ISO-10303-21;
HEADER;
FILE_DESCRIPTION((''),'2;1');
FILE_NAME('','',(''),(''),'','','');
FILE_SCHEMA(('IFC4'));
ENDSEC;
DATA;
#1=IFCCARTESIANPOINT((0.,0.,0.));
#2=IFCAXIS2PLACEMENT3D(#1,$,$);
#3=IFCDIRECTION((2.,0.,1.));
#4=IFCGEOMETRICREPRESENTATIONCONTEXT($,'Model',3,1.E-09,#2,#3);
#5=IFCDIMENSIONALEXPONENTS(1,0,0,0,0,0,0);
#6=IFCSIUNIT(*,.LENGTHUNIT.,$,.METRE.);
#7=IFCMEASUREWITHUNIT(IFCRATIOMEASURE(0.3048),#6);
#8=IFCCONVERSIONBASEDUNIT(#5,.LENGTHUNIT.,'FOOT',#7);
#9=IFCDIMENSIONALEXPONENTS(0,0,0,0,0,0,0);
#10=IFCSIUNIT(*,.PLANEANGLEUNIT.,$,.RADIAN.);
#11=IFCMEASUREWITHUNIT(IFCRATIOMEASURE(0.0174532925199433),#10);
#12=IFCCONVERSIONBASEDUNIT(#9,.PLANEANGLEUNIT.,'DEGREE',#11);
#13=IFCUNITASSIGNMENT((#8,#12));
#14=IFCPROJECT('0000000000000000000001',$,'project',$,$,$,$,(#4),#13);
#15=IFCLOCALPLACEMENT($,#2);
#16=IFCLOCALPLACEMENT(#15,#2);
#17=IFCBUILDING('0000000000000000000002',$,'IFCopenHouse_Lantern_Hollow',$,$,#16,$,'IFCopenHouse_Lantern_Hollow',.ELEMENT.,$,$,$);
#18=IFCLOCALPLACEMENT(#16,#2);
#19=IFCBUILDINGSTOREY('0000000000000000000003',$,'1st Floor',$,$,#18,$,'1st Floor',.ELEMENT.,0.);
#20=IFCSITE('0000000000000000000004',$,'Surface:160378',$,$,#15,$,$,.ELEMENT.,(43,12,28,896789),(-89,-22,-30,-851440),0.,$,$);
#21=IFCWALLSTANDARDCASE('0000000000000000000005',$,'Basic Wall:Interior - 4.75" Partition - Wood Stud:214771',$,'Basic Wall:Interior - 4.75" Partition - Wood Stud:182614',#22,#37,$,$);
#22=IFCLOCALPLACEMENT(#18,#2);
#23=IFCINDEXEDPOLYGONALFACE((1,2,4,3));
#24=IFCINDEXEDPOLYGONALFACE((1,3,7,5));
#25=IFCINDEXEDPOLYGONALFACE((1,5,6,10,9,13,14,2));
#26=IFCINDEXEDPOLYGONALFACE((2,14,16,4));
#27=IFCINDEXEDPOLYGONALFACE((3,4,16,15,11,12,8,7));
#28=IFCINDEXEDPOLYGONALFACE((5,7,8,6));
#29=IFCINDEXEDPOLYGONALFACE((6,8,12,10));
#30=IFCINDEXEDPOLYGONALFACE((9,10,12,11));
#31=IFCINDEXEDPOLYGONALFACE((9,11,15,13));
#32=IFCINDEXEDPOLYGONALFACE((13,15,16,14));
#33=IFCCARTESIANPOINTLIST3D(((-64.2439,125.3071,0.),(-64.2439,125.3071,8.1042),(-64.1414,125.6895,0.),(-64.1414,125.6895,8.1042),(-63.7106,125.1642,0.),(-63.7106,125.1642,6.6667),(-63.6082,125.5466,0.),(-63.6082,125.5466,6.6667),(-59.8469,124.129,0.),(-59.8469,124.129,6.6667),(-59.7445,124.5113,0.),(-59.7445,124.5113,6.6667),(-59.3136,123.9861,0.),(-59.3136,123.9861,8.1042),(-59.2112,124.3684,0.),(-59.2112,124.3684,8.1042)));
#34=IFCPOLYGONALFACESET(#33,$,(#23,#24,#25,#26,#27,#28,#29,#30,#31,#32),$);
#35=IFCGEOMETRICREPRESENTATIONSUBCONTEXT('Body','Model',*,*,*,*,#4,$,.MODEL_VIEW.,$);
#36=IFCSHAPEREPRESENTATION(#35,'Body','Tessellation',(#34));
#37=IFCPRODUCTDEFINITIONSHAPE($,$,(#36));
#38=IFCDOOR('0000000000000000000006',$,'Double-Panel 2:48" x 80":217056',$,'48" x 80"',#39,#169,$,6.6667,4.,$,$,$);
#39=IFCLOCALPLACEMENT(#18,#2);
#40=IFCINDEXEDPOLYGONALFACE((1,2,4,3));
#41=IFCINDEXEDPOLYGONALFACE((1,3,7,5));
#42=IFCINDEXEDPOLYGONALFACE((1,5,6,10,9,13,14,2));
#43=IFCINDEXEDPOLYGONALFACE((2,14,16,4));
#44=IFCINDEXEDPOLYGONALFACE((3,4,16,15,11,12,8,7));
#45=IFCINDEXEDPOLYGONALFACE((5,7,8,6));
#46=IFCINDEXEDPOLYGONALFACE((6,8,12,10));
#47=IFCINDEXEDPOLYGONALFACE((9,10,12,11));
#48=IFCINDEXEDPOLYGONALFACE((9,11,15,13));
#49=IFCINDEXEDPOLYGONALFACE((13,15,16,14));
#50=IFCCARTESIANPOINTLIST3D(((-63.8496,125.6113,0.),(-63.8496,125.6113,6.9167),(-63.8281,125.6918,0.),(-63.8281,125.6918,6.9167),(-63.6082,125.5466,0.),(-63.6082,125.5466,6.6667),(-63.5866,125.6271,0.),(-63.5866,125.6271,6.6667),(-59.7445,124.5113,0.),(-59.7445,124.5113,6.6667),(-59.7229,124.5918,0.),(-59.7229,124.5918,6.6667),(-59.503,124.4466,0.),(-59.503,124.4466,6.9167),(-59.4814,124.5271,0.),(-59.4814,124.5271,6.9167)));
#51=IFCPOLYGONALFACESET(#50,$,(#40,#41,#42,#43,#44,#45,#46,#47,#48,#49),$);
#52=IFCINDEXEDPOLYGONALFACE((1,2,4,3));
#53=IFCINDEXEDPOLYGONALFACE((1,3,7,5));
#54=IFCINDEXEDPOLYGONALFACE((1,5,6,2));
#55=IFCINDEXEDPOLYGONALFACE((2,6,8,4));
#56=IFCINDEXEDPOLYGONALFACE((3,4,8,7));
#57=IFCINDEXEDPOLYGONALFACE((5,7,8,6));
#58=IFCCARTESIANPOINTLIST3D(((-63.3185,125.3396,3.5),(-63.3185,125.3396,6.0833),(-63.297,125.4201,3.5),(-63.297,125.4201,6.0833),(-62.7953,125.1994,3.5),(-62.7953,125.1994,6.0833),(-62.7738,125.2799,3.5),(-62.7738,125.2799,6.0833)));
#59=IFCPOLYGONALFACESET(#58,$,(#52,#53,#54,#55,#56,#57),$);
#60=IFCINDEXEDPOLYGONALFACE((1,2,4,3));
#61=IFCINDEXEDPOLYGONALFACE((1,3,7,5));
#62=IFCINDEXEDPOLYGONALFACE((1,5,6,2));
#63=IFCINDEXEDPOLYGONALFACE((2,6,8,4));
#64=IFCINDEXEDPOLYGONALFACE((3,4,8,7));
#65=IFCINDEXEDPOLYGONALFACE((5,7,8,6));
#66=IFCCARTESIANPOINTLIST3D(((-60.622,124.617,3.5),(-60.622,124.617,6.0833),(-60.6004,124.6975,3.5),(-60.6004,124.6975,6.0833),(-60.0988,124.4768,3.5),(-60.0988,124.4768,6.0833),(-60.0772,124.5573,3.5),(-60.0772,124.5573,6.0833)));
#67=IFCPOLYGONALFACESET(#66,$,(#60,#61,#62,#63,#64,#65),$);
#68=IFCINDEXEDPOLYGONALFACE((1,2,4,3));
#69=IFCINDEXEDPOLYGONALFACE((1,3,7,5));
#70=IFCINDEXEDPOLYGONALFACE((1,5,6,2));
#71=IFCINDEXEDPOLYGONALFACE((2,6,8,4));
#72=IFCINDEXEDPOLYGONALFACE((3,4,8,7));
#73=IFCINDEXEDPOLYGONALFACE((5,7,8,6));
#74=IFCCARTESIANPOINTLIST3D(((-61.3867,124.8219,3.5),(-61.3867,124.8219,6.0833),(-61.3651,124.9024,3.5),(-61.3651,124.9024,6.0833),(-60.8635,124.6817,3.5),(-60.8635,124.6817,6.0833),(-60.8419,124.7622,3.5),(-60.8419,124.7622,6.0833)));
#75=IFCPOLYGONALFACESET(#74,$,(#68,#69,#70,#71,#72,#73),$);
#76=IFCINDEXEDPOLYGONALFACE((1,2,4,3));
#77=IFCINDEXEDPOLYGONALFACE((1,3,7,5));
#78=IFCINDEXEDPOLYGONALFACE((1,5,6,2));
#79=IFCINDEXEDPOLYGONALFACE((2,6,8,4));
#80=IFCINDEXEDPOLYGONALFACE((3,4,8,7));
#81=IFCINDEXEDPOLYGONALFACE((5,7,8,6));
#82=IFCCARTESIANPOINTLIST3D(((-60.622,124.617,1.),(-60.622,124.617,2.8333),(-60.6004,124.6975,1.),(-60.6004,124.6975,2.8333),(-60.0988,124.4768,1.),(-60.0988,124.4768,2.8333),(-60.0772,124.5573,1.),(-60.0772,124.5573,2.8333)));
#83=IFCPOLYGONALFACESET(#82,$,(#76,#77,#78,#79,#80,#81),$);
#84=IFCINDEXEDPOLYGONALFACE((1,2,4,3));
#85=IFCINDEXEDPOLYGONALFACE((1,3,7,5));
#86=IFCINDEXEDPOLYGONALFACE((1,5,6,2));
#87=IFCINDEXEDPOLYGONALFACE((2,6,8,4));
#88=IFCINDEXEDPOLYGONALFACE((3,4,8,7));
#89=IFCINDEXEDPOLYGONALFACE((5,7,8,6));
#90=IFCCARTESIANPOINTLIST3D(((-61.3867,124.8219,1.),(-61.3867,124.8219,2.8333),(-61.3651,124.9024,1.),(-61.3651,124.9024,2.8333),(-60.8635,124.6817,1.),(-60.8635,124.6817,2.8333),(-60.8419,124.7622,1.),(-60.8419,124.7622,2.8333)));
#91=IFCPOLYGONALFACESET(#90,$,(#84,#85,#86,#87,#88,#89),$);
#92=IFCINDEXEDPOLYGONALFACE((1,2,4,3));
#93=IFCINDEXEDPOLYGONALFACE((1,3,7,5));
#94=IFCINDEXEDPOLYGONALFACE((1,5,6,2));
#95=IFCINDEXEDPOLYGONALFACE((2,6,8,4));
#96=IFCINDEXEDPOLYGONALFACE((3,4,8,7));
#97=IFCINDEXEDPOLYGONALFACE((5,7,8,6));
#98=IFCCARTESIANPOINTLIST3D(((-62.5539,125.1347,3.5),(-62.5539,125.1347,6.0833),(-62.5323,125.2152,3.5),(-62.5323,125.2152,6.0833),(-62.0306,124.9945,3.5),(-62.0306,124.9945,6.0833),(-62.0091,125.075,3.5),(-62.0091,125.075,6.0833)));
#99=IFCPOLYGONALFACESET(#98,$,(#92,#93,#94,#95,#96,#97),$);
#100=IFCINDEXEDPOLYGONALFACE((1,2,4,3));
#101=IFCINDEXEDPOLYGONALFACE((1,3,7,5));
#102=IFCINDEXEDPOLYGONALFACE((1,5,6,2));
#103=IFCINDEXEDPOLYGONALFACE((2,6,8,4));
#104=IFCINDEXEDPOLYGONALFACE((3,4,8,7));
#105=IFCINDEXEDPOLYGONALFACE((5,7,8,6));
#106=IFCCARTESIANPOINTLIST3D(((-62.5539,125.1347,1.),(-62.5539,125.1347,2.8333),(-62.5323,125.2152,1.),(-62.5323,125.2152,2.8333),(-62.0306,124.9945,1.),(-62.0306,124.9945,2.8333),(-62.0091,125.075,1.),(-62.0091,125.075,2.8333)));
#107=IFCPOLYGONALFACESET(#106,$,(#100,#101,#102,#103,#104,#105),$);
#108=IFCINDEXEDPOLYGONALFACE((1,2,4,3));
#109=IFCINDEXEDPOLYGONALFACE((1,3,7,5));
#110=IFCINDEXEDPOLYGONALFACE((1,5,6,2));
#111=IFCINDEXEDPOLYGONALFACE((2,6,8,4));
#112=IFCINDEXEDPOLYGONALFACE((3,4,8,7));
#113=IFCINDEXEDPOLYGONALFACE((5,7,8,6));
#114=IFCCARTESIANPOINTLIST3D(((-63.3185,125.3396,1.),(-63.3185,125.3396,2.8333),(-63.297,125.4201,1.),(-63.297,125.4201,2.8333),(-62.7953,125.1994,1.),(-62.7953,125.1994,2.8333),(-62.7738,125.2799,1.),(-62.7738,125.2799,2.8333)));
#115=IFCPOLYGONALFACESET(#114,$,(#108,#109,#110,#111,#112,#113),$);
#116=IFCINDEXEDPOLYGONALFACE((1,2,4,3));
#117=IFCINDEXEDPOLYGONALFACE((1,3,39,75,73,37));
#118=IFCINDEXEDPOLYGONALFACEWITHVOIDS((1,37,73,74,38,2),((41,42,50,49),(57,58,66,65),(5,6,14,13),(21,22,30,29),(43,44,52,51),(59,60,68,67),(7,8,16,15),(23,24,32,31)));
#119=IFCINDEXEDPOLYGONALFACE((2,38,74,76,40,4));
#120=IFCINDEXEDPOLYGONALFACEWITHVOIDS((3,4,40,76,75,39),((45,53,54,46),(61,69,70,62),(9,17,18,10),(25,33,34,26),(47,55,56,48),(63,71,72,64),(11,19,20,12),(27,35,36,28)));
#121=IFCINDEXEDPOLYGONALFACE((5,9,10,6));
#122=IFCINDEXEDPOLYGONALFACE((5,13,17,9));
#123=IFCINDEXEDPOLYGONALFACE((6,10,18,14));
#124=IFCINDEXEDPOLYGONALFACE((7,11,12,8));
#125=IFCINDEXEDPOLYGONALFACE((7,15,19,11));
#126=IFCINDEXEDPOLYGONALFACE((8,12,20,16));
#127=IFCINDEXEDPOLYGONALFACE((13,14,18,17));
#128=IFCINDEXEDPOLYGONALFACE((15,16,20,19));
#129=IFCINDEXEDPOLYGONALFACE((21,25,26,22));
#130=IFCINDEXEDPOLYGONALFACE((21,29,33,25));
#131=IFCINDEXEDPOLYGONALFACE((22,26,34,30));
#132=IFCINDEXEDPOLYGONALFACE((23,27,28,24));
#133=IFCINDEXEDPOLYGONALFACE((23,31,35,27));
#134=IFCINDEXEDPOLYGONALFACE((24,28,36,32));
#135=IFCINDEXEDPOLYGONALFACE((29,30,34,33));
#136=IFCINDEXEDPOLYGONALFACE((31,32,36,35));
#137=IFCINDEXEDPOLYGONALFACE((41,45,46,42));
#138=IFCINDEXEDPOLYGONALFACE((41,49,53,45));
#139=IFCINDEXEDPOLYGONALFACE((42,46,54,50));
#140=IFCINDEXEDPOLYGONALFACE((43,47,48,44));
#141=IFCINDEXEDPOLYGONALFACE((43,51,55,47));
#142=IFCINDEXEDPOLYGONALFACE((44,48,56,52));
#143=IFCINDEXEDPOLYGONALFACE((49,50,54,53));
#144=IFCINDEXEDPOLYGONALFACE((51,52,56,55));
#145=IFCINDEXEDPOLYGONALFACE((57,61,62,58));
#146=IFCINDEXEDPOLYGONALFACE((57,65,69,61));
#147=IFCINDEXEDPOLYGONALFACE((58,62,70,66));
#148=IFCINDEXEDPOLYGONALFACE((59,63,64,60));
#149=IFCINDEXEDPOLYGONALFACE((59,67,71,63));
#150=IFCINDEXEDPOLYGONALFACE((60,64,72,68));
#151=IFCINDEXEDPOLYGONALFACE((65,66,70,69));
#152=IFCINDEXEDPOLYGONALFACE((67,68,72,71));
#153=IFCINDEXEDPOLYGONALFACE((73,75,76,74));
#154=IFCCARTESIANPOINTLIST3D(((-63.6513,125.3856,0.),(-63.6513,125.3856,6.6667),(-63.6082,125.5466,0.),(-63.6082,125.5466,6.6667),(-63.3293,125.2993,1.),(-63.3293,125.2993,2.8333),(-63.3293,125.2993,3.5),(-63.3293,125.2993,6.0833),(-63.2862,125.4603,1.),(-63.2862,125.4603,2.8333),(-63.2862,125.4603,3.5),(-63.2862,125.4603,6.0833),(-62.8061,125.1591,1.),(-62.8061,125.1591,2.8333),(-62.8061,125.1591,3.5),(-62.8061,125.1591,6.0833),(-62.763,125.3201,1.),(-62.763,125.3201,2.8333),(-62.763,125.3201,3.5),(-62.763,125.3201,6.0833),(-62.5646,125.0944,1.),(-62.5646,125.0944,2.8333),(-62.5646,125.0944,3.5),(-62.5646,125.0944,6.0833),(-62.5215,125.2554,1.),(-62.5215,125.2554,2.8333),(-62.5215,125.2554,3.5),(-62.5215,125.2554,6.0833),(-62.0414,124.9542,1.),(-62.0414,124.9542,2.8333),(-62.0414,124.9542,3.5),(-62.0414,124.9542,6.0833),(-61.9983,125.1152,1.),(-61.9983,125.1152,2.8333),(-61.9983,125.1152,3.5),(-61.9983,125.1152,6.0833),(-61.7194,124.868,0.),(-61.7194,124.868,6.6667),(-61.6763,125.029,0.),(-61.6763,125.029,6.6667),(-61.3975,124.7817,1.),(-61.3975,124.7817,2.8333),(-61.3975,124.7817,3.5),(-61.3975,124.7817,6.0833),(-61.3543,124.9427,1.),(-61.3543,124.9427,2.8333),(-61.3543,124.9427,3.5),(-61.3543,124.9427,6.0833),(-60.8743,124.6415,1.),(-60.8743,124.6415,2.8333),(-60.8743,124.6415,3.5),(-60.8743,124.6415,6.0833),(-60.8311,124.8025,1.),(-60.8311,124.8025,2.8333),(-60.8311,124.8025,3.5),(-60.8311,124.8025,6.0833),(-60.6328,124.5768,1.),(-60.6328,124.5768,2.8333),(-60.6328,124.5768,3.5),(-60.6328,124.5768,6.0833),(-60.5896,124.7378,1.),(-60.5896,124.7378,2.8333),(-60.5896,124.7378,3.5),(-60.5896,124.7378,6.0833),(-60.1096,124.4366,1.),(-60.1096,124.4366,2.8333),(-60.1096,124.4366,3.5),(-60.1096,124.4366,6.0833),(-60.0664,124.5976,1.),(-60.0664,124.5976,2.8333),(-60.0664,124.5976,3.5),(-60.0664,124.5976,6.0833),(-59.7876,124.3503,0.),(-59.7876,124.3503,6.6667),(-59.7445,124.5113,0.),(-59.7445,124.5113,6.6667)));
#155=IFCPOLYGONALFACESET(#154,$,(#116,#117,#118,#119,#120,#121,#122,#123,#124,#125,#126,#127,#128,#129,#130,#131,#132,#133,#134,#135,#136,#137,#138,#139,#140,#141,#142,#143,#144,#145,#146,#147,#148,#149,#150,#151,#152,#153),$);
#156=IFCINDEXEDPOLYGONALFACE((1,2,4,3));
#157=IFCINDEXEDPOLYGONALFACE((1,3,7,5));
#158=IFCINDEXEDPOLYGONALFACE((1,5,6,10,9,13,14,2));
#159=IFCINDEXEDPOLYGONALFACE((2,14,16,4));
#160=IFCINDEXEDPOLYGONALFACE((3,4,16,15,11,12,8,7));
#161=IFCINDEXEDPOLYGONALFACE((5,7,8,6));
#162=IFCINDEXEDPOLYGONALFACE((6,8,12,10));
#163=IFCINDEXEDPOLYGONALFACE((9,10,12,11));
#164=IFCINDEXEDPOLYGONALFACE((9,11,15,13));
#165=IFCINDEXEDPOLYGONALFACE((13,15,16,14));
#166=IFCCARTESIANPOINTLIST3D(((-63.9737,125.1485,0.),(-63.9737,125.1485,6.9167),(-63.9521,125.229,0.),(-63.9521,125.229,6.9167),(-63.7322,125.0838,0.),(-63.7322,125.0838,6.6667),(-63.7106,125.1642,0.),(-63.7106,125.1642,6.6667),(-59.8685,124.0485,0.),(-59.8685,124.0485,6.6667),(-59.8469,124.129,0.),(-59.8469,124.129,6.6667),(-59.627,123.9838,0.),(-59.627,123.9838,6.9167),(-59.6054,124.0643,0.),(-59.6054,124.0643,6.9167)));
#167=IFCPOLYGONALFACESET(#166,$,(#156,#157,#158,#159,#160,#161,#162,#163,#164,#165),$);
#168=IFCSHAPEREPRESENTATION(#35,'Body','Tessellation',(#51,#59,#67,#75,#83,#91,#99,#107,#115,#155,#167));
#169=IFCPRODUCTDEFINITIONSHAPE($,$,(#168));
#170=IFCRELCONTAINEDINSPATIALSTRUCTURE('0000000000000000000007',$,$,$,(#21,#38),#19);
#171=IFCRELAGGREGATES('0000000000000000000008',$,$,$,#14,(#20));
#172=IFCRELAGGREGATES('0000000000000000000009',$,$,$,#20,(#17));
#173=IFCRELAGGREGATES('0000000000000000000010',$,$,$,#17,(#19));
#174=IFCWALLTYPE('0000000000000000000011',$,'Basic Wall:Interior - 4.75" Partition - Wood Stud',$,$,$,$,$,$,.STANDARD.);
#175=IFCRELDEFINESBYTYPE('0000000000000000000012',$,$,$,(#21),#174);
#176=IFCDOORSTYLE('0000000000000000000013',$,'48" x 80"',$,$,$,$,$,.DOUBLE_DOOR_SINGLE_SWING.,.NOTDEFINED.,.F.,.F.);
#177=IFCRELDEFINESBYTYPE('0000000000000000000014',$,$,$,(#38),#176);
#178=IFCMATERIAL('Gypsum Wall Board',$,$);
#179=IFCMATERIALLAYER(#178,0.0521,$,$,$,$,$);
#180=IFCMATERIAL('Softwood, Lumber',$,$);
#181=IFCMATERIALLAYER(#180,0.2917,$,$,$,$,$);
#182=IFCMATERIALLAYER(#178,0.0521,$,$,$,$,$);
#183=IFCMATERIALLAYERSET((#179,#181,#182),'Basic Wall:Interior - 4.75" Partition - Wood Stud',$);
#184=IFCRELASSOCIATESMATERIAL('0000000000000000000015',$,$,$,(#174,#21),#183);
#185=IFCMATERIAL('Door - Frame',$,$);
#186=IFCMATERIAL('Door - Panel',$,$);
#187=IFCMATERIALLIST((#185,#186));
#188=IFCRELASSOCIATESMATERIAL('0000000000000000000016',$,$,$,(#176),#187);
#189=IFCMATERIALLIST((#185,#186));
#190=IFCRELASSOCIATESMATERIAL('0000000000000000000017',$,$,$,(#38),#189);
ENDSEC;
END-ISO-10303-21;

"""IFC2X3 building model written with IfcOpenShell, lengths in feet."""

from ifc_helpers import new_model, entity, si_unit, converted_unit, direction, frame, frame_2d, origin, place, context, subcontext, project, spatial, polyline, rectangle, outline, extrude, source, transform, mapped, material, material_list, layer, layer_set, layer_usage, type_object, type_shapes, element, fill, save


model = new_model("IFC2X3")

# Units and contexts
model_context = context("Model", 3, precision=1e-09, world=origin(), true_north=direction((2.0, 0.0, 1.0)))
body_context = subcontext(model_context, "Body", "Model", "MODEL_VIEW")
ifc_project = project(units=[converted_unit("LENGTHUNIT", "FOOT", entity("IfcRatioMeasure", 0.3048), si_unit("LENGTHUNIT", "METRE"), dimensions=[1, 0, 0, 0, 0, 0, 0]), converted_unit("PLANEANGLEUNIT", "DEGREE", entity("IfcRatioMeasure", 0.0174532925199433), si_unit("PLANEANGLEUNIT", "RADIAN"), dimensions=[0, 0, 0, 0, 0, 0, 0])], contexts=[model_context])

# Site, building, storey
site_placement = place(None, origin())
site = spatial("IfcSite", under=ifc_project, at=site_placement, Name="Surface:160378", CompositionType="ELEMENT", RefLatitude=(43, 12, 28, 896789), RefLongitude=(-89, -22, -30, -851440), RefElevation=0.0)
building_placement = place(site_placement, origin())
building = spatial("IfcBuilding", under=site, at=building_placement, Name="IFCopenHouse_Lantern_Hollow", LongName="IFCopenHouse_Lantern_Hollow", CompositionType="ELEMENT")
storey_placement = place(building_placement, origin())
storey = spatial("IfcBuildingStorey", under=building, at=storey_placement, Name="1st Floor", LongName="1st Floor", CompositionType="ELEMENT", Elevation=0.0)

# Shared definitions
ifc_material_1 = material(Name="Softwood, Lumber")
ifc_material_2 = material(Name="Gypsum Wall Board")

# Shared definitions
ifc_layer_1 = layer(ifc_material_2, 0.0521)
ifc_layer_2 = layer(ifc_material_1, 0.2917)
ifc_layer_3 = layer(ifc_material_2, 0.0521)
ifc_layer_set_1 = layer_set([ifc_layer_1, ifc_layer_2, ifc_layer_3], Name="Basic Wall:Interior - 4.75\" Partition - Wood Stud")
wall_type = type_object("IfcWallType", Name="Basic Wall:Interior - 4.75\" Partition - Wood Stud", PredefinedType="STANDARD", material=ifc_layer_set_1)
ifc_material_3 = material(Name="Door - Panel")
ifc_material_4 = material(Name="Door - Frame")

# Wall, opening, door
ifc_layer_usage_1 = layer_usage(ifc_layer_set_1, "AXIS2", "NEGATIVE", 0.1979)
wall_1_placement = place(storey_placement, frame((-59.2624, 124.1773, 0.0), z_axis=(0.0, 0.0, 1.0), x_axis=(-0.965926, 0.258819, 0.0)))
wall_1 = element("IfcWallStandardCase", 1, at=wall_1_placement, inside=storey, type_object=wall_type, material=ifc_layer_usage_1, Name="Basic Wall:Interior - 4.75\" Partition - Wood Stud:214771", ObjectType="Basic Wall:Interior - 4.75\" Partition - Wood Stud:182614", context=body_context, shape_type="SweptSolid", body=[
    extrude(rectangle(XDim=5.1042, YDim=0.3958, at=frame_2d((2.5521, 0.0), x_axis=(-1.0, 0.0))), origin(), (0.0, 0.0, 1.0), 8.1042),
])
opening_1_placement = place(wall_1_placement, frame((4.5521, 0.1979, 0.0)))
opening_1 = element("IfcOpeningElement", 2, at=opening_1_placement, cuts=wall_1, ObjectType="Opening", context=body_context, shape_type="SweptSolid", body=[
    extrude(rectangle(XDim=6.6667, YDim=4.0, at=frame_2d((3.3333, 2.0), x_axis=(1.0, 0.0))), frame((0.0, 0.0, 0.0), z_axis=(0.0, -1.0, 0.0), x_axis=(0.0, 0.0, 1.0)), (0.0, 0.0, 1.0), 0.3958),
])
ifc_material_list_1 = material_list([ifc_material_4, ifc_material_3])
ifc_material_list_2 = material_list([ifc_material_4, ifc_material_3])
door_style_1 = type_object("IfcDoorStyle", Name="48\" x 80\"", ConstructionType="NOTDEFINED", OperationType="DOUBLE_DOOR_SINGLE_SWING", ParameterTakesPrecedence=False, Sizeable=False, material=ifc_material_list_2)
shared_shape_1 = source(origin(), body_context, "Body", "SweptSolid", [
    extrude(outline(polyline([(-2.25, -3.5208), (2.25, -3.5208), (2.25, 3.3958), (2.0, 3.3958), (2.0, -3.2708), (-2.0, -3.2708), (-2.0, 3.3958), (-2.25, 3.3958), (-2.25, -3.5208)])), frame((2.0, 0.3958, 3.3958), z_axis=(0.0, 1.0, 0.0), x_axis=(1.0, 0.0, 0.0)), (0.0, 0.0, 1.0), 0.0833),
    extrude(rectangle(XDim=0.0833, YDim=0.5417, at=frame_2d((0.0, 0.0), x_axis=(1.0, 0.0))), frame((0.6042, 0.3125, 3.5), z_axis=(0.0, 0.0, 1.0), x_axis=(0.0, -1.0, 0.0)), (0.0, 0.0, 1.0), 2.5833),
    extrude(rectangle(XDim=0.0833, YDim=0.5417, at=frame_2d((0.0, 0.0), x_axis=(1.0, 0.0))), frame((3.3958, 0.3125, 3.5), z_axis=(0.0, 0.0, 1.0), x_axis=(0.0, -1.0, 0.0)), (0.0, 0.0, 1.0), 2.5833),
    extrude(rectangle(XDim=0.0833, YDim=0.5417, at=frame_2d((0.0, 0.0), x_axis=(1.0, 0.0))), frame((2.6042, 0.3125, 3.5), z_axis=(0.0, 0.0, 1.0), x_axis=(0.0, -1.0, 0.0)), (0.0, 0.0, 1.0), 2.5833),
    extrude(rectangle(XDim=0.0833, YDim=0.5417, at=frame_2d((0.0, 0.0), x_axis=(1.0, 0.0))), frame((3.3958, 0.3125, 1.0), z_axis=(0.0, 0.0, 1.0), x_axis=(0.0, -1.0, 0.0)), (0.0, 0.0, 1.0), 1.8333),
    extrude(rectangle(XDim=0.0833, YDim=0.5417, at=frame_2d((0.0, 0.0), x_axis=(1.0, 0.0))), frame((2.6042, 0.3125, 1.0), z_axis=(0.0, 0.0, 1.0), x_axis=(0.0, -1.0, 0.0)), (0.0, 0.0, 1.0), 1.8333),
    extrude(rectangle(XDim=0.0833, YDim=0.5417, at=frame_2d((0.0, 0.0), x_axis=(1.0, 0.0))), frame((1.3958, 0.3125, 3.5), z_axis=(0.0, 0.0, 1.0), x_axis=(0.0, -1.0, 0.0)), (0.0, 0.0, 1.0), 2.5833),
    extrude(rectangle(XDim=0.0833, YDim=0.5417, at=frame_2d((0.0, 0.0), x_axis=(1.0, 0.0))), frame((1.3958, 0.3125, 1.0), z_axis=(0.0, 0.0, 1.0), x_axis=(0.0, -1.0, 0.0)), (0.0, 0.0, 1.0), 1.8333),
    extrude(rectangle(XDim=0.0833, YDim=0.5417, at=frame_2d((0.0, 0.0), x_axis=(1.0, 0.0))), frame((0.6042, 0.3125, 1.0), z_axis=(0.0, 0.0, 1.0), x_axis=(0.0, -1.0, 0.0)), (0.0, 0.0, 1.0), 1.8333),
    extrude(outline(polyline([(0.0, -3.3333), (2.0, -3.3333), (2.0, 3.3333), (0.0, 3.3333), (-2.0, 3.3333), (-2.0, -3.3333), (0.0, -3.3333)]), holes=[polyline([(1.125, -2.75), (1.125, -0.1667), (1.6667, -0.1667), (1.6667, -2.75), (1.125, -2.75)]), polyline([(0.3333, -2.75), (0.3333, -0.1667), (0.875, -0.1667), (0.875, -2.75), (0.3333, -2.75)]), polyline([(1.125, 0.5), (1.125, 2.3333), (1.6667, 2.3333), (1.6667, 0.5), (1.125, 0.5)]), polyline([(0.3333, 0.5), (0.3333, 2.3333), (0.875, 2.3333), (0.875, 0.5), (0.3333, 0.5)]), polyline([(-0.875, -0.1667), (-0.3333, -0.1667), (-0.3333, -2.75), (-0.875, -2.75), (-0.875, -0.1667)]), polyline([(-1.6667, -2.75), (-1.6667, -0.1667), (-1.125, -0.1667), (-1.125, -2.75), (-1.6667, -2.75)]), polyline([(-0.875, 0.5), (-0.875, 2.3333), (-0.3333, 2.3333), (-0.3333, 0.5), (-0.875, 0.5)]), polyline([(-1.6667, 0.5), (-1.6667, 2.3333), (-1.125, 2.3333), (-1.125, 0.5), (-1.6667, 0.5)])]), frame((2.0, 0.2292, 3.3333), z_axis=(0.0, 1.0, 0.0), x_axis=(1.0, 0.0, 0.0)), (0.0, 0.0, 1.0), 0.1667),
    extrude(outline(polyline([(-3.2708, 2.0), (3.3958, 2.0), (3.3958, 2.25), (-3.5208, 2.25), (-3.5208, -2.25), (3.3958, -2.25), (3.3958, -2.0), (-3.2708, -2.0), (-3.2708, 2.0)])), frame((2.0, -0.0833, 3.3958), z_axis=(0.0, 1.0, 0.0), x_axis=(0.0, 0.0, -1.0)), (0.0, 0.0, 1.0), 0.0833),
])
type_shapes(door_style_1, [shared_shape_1])
door_1_placement = place(opening_1_placement, frame((0.0, 0.0, 0.0), z_axis=(0.0, 0.0, 1.0), x_axis=(-1.0, 0.0, 0.0)))
door_1 = element("IfcDoor", 3, at=door_1_placement, inside=storey, type_object=door_style_1, material=ifc_material_list_1, Name="Double-Panel 2:48\" x 80\":217056", ObjectType="48\" x 80\"", OverallHeight=6.6667, OverallWidth=4.0, context=body_context, shape_type="MappedRepresentation", body=[
    mapped(shared_shape_1, transform((0.0, 0.0, 0.0), scale=1.0)),
])
fill(opening_1, door_1)

save(model, "model.ifc")
